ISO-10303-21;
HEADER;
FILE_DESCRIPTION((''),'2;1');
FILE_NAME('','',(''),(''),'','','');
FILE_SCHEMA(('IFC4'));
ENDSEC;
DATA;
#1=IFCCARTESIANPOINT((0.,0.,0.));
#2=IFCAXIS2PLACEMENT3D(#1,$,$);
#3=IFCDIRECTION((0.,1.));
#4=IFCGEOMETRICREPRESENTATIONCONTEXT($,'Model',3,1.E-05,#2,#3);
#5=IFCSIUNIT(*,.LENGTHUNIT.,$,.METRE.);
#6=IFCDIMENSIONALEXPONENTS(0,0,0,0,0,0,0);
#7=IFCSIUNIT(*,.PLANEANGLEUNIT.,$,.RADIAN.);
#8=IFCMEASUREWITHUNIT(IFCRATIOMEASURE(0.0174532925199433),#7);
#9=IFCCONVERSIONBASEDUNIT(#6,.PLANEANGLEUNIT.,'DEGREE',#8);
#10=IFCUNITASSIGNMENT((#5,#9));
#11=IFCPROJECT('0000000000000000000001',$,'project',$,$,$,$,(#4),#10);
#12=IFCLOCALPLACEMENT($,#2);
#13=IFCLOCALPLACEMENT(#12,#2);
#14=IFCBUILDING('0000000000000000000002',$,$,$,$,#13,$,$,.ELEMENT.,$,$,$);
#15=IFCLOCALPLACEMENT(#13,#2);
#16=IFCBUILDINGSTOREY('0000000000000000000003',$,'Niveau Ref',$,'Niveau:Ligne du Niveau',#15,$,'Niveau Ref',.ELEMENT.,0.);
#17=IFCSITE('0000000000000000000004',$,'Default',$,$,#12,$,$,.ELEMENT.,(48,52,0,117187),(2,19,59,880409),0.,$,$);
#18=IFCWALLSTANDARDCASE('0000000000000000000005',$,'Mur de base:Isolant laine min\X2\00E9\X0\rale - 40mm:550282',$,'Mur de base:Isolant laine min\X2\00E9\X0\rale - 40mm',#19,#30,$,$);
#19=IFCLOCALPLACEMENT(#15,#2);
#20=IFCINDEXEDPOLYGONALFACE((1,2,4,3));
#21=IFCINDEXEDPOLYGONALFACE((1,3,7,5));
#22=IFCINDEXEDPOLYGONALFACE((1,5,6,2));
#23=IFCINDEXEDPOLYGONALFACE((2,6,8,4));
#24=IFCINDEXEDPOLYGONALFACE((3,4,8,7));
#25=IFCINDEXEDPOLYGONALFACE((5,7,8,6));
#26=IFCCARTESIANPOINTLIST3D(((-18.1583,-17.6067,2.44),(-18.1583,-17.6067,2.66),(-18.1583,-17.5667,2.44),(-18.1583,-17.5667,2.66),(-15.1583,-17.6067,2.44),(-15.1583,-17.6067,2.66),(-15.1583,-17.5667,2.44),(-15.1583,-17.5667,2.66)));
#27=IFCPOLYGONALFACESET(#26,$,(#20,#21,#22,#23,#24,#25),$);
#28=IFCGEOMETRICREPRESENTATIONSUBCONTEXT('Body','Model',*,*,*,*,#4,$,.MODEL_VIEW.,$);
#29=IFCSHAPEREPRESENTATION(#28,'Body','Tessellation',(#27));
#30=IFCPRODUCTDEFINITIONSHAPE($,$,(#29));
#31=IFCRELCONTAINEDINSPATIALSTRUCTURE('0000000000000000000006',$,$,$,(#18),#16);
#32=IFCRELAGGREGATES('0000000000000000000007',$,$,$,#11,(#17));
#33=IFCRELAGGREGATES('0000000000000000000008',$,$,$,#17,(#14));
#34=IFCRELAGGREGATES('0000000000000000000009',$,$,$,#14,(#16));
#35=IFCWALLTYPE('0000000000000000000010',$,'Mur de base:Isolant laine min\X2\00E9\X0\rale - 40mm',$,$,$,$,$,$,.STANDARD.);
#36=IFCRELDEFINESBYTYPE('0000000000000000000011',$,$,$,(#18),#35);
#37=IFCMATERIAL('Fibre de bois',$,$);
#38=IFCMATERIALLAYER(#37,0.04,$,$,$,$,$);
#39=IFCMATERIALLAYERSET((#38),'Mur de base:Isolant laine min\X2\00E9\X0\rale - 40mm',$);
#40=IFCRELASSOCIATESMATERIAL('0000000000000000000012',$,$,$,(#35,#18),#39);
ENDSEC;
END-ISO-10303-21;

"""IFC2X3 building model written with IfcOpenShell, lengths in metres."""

from ifc_helpers import new_model, entity, si_unit, converted_unit, direction, frame, frame_2d, origin, place, context, subcontext, project, spatial, rectangle, extrude, material, layer, layer_set, layer_usage, type_object, element, save


model = new_model("IFC2X3")

# Units and contexts
model_context = context("Model", 3, precision=1e-05, world=origin(), true_north=direction((0.0, 1.0)))
body_context = subcontext(model_context, "Body", "Model", "MODEL_VIEW")
ifc_project = project(units=[si_unit("LENGTHUNIT", "METRE"), converted_unit("PLANEANGLEUNIT", "DEGREE", entity("IfcRatioMeasure", 0.0174532925199433), si_unit("PLANEANGLEUNIT", "RADIAN"), dimensions=[0, 0, 0, 0, 0, 0, 0])], contexts=[model_context])

# Site, building, storey
site_placement = place(None, origin())
site = spatial("IfcSite", under=ifc_project, at=site_placement, Name="Default", CompositionType="ELEMENT", RefLatitude=(48, 52, 0, 117187), RefLongitude=(2, 19, 59, 880409), RefElevation=0.0)
building_placement = place(site_placement, origin())
building = spatial("IfcBuilding", under=site, at=building_placement, CompositionType="ELEMENT")
storey_placement = place(building_placement, origin())
storey = spatial("IfcBuildingStorey", under=building, at=storey_placement, Name="Niveau Ref", ObjectType="Niveau:Ligne du Niveau", LongName="Niveau Ref", CompositionType="ELEMENT", Elevation=0.0)

# Wall
ifc_material_1 = material(Name="Fibre de bois")
ifc_layer = layer(ifc_material_1, 0.04)
ifc_layer_set = layer_set([ifc_layer], Name="Mur de base:Isolant laine minérale - 40mm")
wall_type = type_object("IfcWallType", Name="Mur de base:Isolant laine minérale - 40mm", PredefinedType="STANDARD", material=ifc_layer_set)
ifc_layer_usage_1 = layer_usage(ifc_layer_set, "AXIS2", "NEGATIVE", 0.02)
wall_1_placement = place(storey_placement, frame((-18.1583, -17.5867, 2.44)))
element("IfcWallStandardCase", 1, at=wall_1_placement, inside=storey, type_object=wall_type, material=ifc_layer_usage_1, Name="Mur de base:Isolant laine minérale - 40mm:550282", ObjectType="Mur de base:Isolant laine minérale - 40mm", context=body_context, shape_type="SweptSolid", body=[
    extrude(rectangle(XDim=3.0, YDim=0.04, at=frame_2d((1.5, 0.0), x_axis=(-1.0, 0.0))), origin(), (0.0, 0.0, 1.0), 0.22),
])

save(model, "model.ifc")
